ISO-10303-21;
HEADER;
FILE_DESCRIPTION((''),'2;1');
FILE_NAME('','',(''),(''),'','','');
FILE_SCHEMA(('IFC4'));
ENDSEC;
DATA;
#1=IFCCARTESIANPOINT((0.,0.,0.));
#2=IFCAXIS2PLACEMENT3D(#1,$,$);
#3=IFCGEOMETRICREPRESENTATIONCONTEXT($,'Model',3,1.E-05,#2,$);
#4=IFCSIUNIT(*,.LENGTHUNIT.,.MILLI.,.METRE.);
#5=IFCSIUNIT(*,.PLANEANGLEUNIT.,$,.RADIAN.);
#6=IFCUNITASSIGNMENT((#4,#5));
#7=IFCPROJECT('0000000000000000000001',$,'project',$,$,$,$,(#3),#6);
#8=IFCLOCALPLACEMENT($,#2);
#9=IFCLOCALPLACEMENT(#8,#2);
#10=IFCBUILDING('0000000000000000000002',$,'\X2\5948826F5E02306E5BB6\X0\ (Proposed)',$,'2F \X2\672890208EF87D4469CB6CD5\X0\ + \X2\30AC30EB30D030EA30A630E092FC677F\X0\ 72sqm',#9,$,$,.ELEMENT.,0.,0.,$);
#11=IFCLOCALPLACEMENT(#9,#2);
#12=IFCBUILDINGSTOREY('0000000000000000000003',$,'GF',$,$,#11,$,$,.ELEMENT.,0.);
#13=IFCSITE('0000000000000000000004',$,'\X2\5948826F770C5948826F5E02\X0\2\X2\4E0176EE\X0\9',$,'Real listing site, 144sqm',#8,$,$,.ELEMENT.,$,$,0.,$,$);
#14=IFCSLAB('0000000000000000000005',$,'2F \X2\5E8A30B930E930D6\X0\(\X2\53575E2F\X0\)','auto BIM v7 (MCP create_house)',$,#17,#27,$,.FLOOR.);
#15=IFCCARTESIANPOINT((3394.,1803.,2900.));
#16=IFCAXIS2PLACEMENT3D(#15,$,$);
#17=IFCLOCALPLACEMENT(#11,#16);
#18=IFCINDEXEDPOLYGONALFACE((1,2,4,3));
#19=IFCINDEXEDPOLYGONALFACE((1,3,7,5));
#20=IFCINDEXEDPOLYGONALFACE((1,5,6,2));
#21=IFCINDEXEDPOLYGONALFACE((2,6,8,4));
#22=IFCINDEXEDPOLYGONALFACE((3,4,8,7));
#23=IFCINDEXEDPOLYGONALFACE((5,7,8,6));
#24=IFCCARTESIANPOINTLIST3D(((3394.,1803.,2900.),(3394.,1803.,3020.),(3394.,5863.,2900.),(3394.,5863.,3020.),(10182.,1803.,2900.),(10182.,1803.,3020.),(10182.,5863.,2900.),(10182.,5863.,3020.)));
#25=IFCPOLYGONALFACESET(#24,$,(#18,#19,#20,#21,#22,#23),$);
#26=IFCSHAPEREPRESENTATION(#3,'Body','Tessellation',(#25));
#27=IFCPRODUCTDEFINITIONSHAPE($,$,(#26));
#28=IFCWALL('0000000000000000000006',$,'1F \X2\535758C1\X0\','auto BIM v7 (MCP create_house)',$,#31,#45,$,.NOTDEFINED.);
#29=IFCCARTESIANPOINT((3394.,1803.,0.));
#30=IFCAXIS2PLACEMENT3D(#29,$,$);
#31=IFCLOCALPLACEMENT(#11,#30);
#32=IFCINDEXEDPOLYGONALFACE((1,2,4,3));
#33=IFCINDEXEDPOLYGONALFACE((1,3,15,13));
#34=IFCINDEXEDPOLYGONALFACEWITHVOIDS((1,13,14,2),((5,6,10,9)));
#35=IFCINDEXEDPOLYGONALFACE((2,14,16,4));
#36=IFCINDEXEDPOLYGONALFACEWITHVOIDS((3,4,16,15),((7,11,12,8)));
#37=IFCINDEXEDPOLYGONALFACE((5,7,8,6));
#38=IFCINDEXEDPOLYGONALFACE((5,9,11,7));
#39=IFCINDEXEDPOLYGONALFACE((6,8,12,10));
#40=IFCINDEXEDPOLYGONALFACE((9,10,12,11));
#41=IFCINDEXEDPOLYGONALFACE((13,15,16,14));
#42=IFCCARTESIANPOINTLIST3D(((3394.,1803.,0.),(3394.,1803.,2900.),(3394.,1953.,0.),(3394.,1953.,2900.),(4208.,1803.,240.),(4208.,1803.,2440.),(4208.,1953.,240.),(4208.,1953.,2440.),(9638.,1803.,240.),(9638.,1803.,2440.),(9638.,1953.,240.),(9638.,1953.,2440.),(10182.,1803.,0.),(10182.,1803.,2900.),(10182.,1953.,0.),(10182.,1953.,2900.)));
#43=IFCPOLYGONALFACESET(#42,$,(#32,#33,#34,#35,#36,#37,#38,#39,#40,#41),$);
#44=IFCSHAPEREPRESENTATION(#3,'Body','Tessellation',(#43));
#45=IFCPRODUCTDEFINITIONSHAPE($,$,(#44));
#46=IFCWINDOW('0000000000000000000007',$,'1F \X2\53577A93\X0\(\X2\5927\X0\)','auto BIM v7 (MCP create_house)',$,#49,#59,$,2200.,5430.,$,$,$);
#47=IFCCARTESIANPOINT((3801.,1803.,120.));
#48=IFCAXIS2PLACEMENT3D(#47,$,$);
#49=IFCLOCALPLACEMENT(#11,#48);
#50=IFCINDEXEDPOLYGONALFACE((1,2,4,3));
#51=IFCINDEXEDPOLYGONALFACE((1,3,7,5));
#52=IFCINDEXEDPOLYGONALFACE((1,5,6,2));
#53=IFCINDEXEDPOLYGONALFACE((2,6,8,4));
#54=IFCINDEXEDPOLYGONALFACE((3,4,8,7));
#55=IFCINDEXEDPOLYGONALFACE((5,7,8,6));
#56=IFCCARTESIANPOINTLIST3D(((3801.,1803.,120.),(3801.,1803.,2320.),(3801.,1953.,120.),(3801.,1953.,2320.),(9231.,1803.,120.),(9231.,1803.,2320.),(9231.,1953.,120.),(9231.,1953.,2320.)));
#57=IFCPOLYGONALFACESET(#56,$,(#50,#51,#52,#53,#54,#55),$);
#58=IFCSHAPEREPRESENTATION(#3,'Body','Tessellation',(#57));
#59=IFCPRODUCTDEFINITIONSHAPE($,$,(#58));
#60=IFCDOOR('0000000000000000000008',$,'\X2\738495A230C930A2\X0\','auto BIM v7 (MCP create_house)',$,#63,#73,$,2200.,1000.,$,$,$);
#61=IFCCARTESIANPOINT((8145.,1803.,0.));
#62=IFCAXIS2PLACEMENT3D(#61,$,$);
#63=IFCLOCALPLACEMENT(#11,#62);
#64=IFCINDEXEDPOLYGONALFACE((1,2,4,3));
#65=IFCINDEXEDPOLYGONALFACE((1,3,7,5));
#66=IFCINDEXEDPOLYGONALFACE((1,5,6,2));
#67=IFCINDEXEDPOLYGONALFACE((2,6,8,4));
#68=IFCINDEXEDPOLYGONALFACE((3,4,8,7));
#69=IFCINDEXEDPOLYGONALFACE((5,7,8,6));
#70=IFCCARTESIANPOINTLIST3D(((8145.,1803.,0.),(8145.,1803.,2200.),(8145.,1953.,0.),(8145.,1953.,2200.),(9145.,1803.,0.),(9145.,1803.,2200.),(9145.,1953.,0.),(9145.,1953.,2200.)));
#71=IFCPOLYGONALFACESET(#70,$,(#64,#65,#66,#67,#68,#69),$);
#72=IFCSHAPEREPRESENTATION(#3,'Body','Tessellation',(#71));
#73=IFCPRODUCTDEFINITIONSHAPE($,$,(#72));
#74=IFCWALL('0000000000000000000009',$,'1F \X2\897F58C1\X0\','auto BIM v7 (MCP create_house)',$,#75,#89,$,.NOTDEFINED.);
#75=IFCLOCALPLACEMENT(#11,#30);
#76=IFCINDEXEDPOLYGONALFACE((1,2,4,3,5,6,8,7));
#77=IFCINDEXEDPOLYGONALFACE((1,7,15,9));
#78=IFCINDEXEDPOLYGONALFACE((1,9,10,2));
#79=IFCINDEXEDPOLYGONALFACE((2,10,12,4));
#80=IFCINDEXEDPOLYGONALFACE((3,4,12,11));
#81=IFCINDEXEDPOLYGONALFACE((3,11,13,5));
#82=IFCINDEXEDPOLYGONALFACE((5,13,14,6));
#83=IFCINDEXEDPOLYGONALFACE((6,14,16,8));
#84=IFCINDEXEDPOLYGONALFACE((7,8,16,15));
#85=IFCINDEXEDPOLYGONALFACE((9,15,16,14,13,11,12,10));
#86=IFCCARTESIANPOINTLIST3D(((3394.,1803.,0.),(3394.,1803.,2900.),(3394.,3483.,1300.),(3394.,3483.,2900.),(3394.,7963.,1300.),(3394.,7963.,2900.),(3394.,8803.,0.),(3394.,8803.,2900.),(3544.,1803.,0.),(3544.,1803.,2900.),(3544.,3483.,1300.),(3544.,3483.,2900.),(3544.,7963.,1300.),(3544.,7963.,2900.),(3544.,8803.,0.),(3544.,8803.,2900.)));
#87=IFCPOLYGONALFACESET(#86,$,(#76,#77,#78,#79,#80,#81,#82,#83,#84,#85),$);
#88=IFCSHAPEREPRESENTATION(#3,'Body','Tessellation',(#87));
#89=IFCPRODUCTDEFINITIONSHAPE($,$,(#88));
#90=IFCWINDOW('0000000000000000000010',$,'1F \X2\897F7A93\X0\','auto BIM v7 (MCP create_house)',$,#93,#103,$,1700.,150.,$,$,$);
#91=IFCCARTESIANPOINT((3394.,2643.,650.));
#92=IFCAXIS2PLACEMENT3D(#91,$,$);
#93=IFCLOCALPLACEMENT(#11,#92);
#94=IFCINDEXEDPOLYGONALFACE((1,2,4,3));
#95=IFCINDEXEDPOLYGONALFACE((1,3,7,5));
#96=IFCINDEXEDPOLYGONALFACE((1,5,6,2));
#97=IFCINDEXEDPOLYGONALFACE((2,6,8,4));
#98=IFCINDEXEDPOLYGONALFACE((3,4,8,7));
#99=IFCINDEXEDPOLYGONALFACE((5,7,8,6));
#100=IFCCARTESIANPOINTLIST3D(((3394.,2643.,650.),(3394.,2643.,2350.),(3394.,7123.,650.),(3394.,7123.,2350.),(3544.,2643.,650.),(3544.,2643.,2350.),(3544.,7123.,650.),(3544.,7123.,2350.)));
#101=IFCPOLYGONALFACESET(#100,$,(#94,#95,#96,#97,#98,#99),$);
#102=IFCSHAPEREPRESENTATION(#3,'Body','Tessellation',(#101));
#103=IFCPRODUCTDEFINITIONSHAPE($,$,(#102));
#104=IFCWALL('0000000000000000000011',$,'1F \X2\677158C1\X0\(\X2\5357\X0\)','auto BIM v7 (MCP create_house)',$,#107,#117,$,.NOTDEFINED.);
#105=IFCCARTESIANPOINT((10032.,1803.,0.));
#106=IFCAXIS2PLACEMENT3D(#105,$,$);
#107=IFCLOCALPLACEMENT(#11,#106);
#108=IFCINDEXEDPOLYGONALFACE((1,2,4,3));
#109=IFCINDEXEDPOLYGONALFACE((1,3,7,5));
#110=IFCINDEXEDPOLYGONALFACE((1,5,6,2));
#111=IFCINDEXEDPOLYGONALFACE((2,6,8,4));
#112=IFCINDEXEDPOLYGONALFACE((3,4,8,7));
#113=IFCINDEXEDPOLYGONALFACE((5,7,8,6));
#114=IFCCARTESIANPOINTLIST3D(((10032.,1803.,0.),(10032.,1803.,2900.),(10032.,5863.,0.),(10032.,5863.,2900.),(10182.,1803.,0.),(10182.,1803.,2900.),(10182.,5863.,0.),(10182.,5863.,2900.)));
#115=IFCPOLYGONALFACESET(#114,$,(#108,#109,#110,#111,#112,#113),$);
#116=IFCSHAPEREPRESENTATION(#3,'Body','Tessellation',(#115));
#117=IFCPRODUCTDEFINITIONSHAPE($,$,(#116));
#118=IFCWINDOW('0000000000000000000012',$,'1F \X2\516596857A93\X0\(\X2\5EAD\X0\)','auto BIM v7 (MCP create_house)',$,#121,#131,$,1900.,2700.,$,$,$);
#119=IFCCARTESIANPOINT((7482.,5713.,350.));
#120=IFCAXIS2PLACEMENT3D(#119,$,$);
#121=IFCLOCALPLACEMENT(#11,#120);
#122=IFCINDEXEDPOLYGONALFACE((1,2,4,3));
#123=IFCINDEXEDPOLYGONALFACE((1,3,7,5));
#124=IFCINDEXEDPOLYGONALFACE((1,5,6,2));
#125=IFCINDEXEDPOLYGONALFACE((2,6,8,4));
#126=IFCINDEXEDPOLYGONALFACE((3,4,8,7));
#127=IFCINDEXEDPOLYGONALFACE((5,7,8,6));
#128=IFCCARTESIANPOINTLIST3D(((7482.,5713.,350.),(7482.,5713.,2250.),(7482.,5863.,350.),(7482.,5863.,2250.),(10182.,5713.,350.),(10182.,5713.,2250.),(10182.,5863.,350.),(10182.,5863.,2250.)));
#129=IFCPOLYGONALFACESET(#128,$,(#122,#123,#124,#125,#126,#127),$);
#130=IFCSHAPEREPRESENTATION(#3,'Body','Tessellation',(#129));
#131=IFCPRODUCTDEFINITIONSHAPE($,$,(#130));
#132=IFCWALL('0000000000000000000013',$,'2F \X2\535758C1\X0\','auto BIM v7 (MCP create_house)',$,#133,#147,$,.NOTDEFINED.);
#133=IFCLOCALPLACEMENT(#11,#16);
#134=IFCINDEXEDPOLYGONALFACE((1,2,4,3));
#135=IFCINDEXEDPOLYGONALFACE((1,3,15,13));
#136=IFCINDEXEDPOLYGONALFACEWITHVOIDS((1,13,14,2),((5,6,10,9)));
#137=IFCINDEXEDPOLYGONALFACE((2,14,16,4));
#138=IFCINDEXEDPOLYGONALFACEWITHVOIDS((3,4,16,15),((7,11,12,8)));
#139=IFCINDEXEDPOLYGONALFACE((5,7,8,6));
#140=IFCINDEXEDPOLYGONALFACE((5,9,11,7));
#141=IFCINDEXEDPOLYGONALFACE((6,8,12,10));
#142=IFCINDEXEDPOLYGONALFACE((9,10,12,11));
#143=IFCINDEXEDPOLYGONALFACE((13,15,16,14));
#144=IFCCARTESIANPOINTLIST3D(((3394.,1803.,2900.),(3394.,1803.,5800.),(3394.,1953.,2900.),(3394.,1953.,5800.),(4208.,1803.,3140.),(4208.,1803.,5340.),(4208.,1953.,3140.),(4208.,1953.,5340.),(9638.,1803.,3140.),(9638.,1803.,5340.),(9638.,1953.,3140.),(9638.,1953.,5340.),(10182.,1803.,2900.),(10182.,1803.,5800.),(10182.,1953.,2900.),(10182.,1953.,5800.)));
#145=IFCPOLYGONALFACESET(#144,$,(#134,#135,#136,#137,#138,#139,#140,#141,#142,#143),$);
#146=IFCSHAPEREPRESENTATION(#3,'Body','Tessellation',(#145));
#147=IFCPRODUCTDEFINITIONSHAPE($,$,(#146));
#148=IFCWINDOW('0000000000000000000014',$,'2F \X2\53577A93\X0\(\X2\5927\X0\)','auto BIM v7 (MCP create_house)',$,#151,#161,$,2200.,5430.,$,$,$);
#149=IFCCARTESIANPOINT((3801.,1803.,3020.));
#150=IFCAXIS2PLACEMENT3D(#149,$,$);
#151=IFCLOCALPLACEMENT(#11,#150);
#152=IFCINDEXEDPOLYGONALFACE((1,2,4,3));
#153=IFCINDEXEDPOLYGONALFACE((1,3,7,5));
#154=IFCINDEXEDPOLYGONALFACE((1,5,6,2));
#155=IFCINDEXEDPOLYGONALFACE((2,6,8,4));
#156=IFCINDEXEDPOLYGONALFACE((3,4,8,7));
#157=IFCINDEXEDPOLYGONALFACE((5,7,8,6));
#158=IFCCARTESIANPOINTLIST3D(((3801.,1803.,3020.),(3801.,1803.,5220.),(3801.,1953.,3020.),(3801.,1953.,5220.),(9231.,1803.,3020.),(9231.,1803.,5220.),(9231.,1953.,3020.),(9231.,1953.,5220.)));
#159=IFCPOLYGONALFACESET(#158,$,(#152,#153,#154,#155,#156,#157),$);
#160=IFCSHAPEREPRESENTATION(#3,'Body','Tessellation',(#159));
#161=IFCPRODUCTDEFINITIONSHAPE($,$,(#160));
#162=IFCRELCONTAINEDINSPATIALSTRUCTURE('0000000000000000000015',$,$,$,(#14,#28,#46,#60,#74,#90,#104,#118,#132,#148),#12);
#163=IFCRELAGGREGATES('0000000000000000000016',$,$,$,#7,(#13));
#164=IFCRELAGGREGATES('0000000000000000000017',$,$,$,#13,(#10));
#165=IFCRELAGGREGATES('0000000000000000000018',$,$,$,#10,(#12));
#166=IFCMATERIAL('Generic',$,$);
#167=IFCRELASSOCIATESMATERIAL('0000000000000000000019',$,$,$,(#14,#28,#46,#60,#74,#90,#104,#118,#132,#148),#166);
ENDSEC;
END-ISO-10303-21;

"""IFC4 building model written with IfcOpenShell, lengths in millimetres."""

from ifc_helpers import new_model, si_unit, frame, frame_2d, origin, place, context, project, spatial, rectangle, extrude, material, element, fill, save


model = new_model("IFC4")

# Units and contexts
model_context = context("Model", 3, precision=1e-05, world=origin())
ifc_project = project(units=[si_unit("LENGTHUNIT", "METRE", prefix="MILLI"), si_unit("PLANEANGLEUNIT", "RADIAN")], contexts=[model_context])

# Site, building, storey
site_placement = place(None, origin())
site = spatial("IfcSite", under=ifc_project, at=site_placement, Name="奈良県奈良市2丁目9", ObjectType="Real listing site, 144sqm", CompositionType="ELEMENT", RefElevation=0.0)
building_placement = place(site_placement, origin())
building = spatial("IfcBuilding", under=site, at=building_placement, Name="奈良市の家 (Proposed)", ObjectType="2F 木造軸組構法 + ガルバリウム鋼板 72sqm", CompositionType="ELEMENT", ElevationOfRefHeight=0.0, ElevationOfTerrain=0.0)
storey_placement = place(building_placement, origin())
storey = spatial("IfcBuildingStorey", under=building, at=storey_placement, Name="GF", CompositionType="ELEMENT", Elevation=0.0)

# Slab
ifc_material = material(Name="Generic")
slab_1_placement = place(storey_placement, frame((3394.0, 1803.0, 2900.0)))
element("IfcSlab", 1, at=slab_1_placement, inside=storey, material=ifc_material, Name="2F 床スラブ(南帯)", Description="auto BIM v7 (MCP create_house)", PredefinedType="FLOOR", context=model_context, shape_type="SweptSolid", body=[
    extrude(rectangle(XDim=6788.0, YDim=4060.0, at=frame_2d((3394.0, 2030.0))), frame((3394.0, 1803.0, 2900.0)), (0.0, 0.0, 1.0), 120.0),
])

# Wall, openings, window, door
wall_1_placement = place(storey_placement, frame((3394.0, 1803.0, 0.0)))
wall_1 = element("IfcWall", 2, at=wall_1_placement, inside=storey, material=ifc_material, Name="1F 南壁", Description="auto BIM v7 (MCP create_house)", PredefinedType="NOTDEFINED", context=model_context, shape_type="SweptSolid", body=[
    extrude(rectangle(XDim=6788.0, YDim=150.0, at=frame_2d((3394.0, 75.0))), frame((3394.0, 1803.0, 0.0)), (0.0, 0.0, 1.0), 2900.0),
])
opening_1_placement = place(storey_placement, frame((3801.0, 1803.0, 120.0)))
opening_1 = element("IfcOpeningElement", 3, at=opening_1_placement, cuts=wall_1, PredefinedType="NOTDEFINED", context=model_context, shape_type="SweptSolid", body=[
    extrude(rectangle(XDim=5430.0, YDim=150.0, at=frame_2d((2715.0, 75.0))), frame((3801.0, 1803.0, 120.0)), (0.0, 0.0, 1.0), 2200.0),
])
opening_2_placement = place(storey_placement, frame((8145.0, 1803.0, 0.0)))
opening_2 = element("IfcOpeningElement", 4, at=opening_2_placement, cuts=wall_1, PredefinedType="NOTDEFINED", context=model_context, shape_type="SweptSolid", body=[
    extrude(rectangle(XDim=1000.0, YDim=150.0, at=frame_2d((500.0, 75.0))), frame((8145.0, 1803.0, 0.0)), (0.0, 0.0, 1.0), 2200.0),
])
window_1_placement = place(storey_placement, frame((3801.0, 1803.0, 120.0)))
window_1 = element("IfcWindow", 5, at=window_1_placement, inside=storey, material=ifc_material, Name="1F 南窓(大)", Description="auto BIM v7 (MCP create_house)", OverallHeight=2200.0, OverallWidth=5430.0, context=model_context, shape_type="SweptSolid", body=[
    extrude(rectangle(XDim=5430.0, YDim=150.0, at=frame_2d((2715.0, 75.0))), frame((3801.0, 1803.0, 120.0)), (0.0, 0.0, 1.0), 2200.0),
])
fill(opening_1, window_1)
door_placement = place(storey_placement, frame((8145.0, 1803.0, 0.0)))
door = element("IfcDoor", 6, at=door_placement, inside=storey, material=ifc_material, Name="玄関ドア", Description="auto BIM v7 (MCP create_house)", OverallHeight=2200.0, OverallWidth=1000.0, context=model_context, shape_type="SweptSolid", body=[
    extrude(rectangle(XDim=1000.0, YDim=150.0, at=frame_2d((500.0, 75.0))), frame((8145.0, 1803.0, 0.0)), (0.0, 0.0, 1.0), 2200.0),
])
fill(opening_2, door)

# Walls, openings, windows
wall_2_placement = place(storey_placement, frame((3394.0, 1803.0, 0.0)))
wall_2 = element("IfcWall", 7, at=wall_2_placement, inside=storey, material=ifc_material, Name="1F 西壁", Description="auto BIM v7 (MCP create_house)", PredefinedType="NOTDEFINED", context=model_context, shape_type="SweptSolid", body=[
    extrude(rectangle(XDim=150.0, YDim=7000.0, at=frame_2d((75.0, 3500.0))), frame((3394.0, 1803.0, 0.0)), (0.0, 0.0, 1.0), 2900.0),
])
opening_3_placement = place(storey_placement, frame((3394.0, 2643.0, 650.0)))
opening_3 = element("IfcOpeningElement", 8, at=opening_3_placement, cuts=wall_2, PredefinedType="NOTDEFINED", context=model_context, shape_type="SweptSolid", body=[
    extrude(rectangle(XDim=150.0, YDim=4480.0, at=frame_2d((75.0, 2240.0))), frame((3394.0, 2643.0, 650.0)), (0.0, 0.0, 1.0), 1700.0),
])
window_2_placement = place(storey_placement, frame((3394.0, 2643.0, 650.0)))
window_2 = element("IfcWindow", 9, at=window_2_placement, inside=storey, material=ifc_material, Name="1F 西窓", Description="auto BIM v7 (MCP create_house)", OverallHeight=1700.0, OverallWidth=150.0, context=model_context, shape_type="SweptSolid", body=[
    extrude(rectangle(XDim=150.0, YDim=4480.0, at=frame_2d((75.0, 2240.0))), frame((3394.0, 2643.0, 650.0)), (0.0, 0.0, 1.0), 1700.0),
])
fill(opening_3, window_2)
wall_3_placement = place(storey_placement, frame((10032.0, 1803.0, 0.0)))
wall_3 = element("IfcWall", 10, at=wall_3_placement, inside=storey, material=ifc_material, Name="1F 東壁(南)", Description="auto BIM v7 (MCP create_house)", PredefinedType="NOTDEFINED", context=model_context, shape_type="SweptSolid", body=[
    extrude(rectangle(XDim=150.0, YDim=4060.0, at=frame_2d((75.0, 2030.0))), frame((10032.0, 1803.0, 0.0)), (0.0, 0.0, 1.0), 2900.0),
])
opening_4_placement = place(storey_placement, frame((7482.0, 5713.0, 350.0)))
opening_4 = element("IfcOpeningElement", 11, at=opening_4_placement, cuts=wall_3, PredefinedType="NOTDEFINED", context=model_context, shape_type="SweptSolid", body=[
    extrude(rectangle(XDim=2700.0, YDim=150.0, at=frame_2d((1350.0, 75.0))), frame((7482.0, 5713.0, 350.0)), (0.0, 0.0, 1.0), 1900.0),
])
window_3_placement = place(storey_placement, frame((7482.0, 5713.0, 350.0)))
window_3 = element("IfcWindow", 12, at=window_3_placement, inside=storey, material=ifc_material, Name="1F 入隅窓(庭)", Description="auto BIM v7 (MCP create_house)", OverallHeight=1900.0, OverallWidth=2700.0, context=model_context, shape_type="SweptSolid", body=[
    extrude(rectangle(XDim=2700.0, YDim=150.0, at=frame_2d((1350.0, 75.0))), frame((7482.0, 5713.0, 350.0)), (0.0, 0.0, 1.0), 1900.0),
])
fill(opening_4, window_3)

# Wall, opening, window
wall_4_placement = place(storey_placement, frame((3394.0, 1803.0, 2900.0)))
wall_4 = element("IfcWall", 13, at=wall_4_placement, inside=storey, material=ifc_material, Name="2F 南壁", Description="auto BIM v7 (MCP create_house)", PredefinedType="NOTDEFINED", context=model_context, shape_type="SweptSolid", body=[
    extrude(rectangle(XDim=6788.0, YDim=150.0, at=frame_2d((3394.0, 75.0))), frame((3394.0, 1803.0, 2900.0)), (0.0, 0.0, 1.0), 2900.0),
])
opening_5_placement = place(storey_placement, frame((3801.0, 1803.0, 3020.0)))
opening_5 = element("IfcOpeningElement", 14, at=opening_5_placement, cuts=wall_4, PredefinedType="NOTDEFINED", context=model_context, shape_type="SweptSolid", body=[
    extrude(rectangle(XDim=5430.0, YDim=150.0, at=frame_2d((2715.0, 75.0))), frame((3801.0, 1803.0, 3020.0)), (0.0, 0.0, 1.0), 2200.0),
])
window_4_placement = place(storey_placement, frame((3801.0, 1803.0, 3020.0)))
window_4 = element("IfcWindow", 15, at=window_4_placement, inside=storey, material=ifc_material, Name="2F 南窓(大)", Description="auto BIM v7 (MCP create_house)", OverallHeight=2200.0, OverallWidth=5430.0, context=model_context, shape_type="SweptSolid", body=[
    extrude(rectangle(XDim=5430.0, YDim=150.0, at=frame_2d((2715.0, 75.0))), frame((3801.0, 1803.0, 3020.0)), (0.0, 0.0, 1.0), 2200.0),
])
fill(opening_5, window_4)

save(model, "model.ifc")
